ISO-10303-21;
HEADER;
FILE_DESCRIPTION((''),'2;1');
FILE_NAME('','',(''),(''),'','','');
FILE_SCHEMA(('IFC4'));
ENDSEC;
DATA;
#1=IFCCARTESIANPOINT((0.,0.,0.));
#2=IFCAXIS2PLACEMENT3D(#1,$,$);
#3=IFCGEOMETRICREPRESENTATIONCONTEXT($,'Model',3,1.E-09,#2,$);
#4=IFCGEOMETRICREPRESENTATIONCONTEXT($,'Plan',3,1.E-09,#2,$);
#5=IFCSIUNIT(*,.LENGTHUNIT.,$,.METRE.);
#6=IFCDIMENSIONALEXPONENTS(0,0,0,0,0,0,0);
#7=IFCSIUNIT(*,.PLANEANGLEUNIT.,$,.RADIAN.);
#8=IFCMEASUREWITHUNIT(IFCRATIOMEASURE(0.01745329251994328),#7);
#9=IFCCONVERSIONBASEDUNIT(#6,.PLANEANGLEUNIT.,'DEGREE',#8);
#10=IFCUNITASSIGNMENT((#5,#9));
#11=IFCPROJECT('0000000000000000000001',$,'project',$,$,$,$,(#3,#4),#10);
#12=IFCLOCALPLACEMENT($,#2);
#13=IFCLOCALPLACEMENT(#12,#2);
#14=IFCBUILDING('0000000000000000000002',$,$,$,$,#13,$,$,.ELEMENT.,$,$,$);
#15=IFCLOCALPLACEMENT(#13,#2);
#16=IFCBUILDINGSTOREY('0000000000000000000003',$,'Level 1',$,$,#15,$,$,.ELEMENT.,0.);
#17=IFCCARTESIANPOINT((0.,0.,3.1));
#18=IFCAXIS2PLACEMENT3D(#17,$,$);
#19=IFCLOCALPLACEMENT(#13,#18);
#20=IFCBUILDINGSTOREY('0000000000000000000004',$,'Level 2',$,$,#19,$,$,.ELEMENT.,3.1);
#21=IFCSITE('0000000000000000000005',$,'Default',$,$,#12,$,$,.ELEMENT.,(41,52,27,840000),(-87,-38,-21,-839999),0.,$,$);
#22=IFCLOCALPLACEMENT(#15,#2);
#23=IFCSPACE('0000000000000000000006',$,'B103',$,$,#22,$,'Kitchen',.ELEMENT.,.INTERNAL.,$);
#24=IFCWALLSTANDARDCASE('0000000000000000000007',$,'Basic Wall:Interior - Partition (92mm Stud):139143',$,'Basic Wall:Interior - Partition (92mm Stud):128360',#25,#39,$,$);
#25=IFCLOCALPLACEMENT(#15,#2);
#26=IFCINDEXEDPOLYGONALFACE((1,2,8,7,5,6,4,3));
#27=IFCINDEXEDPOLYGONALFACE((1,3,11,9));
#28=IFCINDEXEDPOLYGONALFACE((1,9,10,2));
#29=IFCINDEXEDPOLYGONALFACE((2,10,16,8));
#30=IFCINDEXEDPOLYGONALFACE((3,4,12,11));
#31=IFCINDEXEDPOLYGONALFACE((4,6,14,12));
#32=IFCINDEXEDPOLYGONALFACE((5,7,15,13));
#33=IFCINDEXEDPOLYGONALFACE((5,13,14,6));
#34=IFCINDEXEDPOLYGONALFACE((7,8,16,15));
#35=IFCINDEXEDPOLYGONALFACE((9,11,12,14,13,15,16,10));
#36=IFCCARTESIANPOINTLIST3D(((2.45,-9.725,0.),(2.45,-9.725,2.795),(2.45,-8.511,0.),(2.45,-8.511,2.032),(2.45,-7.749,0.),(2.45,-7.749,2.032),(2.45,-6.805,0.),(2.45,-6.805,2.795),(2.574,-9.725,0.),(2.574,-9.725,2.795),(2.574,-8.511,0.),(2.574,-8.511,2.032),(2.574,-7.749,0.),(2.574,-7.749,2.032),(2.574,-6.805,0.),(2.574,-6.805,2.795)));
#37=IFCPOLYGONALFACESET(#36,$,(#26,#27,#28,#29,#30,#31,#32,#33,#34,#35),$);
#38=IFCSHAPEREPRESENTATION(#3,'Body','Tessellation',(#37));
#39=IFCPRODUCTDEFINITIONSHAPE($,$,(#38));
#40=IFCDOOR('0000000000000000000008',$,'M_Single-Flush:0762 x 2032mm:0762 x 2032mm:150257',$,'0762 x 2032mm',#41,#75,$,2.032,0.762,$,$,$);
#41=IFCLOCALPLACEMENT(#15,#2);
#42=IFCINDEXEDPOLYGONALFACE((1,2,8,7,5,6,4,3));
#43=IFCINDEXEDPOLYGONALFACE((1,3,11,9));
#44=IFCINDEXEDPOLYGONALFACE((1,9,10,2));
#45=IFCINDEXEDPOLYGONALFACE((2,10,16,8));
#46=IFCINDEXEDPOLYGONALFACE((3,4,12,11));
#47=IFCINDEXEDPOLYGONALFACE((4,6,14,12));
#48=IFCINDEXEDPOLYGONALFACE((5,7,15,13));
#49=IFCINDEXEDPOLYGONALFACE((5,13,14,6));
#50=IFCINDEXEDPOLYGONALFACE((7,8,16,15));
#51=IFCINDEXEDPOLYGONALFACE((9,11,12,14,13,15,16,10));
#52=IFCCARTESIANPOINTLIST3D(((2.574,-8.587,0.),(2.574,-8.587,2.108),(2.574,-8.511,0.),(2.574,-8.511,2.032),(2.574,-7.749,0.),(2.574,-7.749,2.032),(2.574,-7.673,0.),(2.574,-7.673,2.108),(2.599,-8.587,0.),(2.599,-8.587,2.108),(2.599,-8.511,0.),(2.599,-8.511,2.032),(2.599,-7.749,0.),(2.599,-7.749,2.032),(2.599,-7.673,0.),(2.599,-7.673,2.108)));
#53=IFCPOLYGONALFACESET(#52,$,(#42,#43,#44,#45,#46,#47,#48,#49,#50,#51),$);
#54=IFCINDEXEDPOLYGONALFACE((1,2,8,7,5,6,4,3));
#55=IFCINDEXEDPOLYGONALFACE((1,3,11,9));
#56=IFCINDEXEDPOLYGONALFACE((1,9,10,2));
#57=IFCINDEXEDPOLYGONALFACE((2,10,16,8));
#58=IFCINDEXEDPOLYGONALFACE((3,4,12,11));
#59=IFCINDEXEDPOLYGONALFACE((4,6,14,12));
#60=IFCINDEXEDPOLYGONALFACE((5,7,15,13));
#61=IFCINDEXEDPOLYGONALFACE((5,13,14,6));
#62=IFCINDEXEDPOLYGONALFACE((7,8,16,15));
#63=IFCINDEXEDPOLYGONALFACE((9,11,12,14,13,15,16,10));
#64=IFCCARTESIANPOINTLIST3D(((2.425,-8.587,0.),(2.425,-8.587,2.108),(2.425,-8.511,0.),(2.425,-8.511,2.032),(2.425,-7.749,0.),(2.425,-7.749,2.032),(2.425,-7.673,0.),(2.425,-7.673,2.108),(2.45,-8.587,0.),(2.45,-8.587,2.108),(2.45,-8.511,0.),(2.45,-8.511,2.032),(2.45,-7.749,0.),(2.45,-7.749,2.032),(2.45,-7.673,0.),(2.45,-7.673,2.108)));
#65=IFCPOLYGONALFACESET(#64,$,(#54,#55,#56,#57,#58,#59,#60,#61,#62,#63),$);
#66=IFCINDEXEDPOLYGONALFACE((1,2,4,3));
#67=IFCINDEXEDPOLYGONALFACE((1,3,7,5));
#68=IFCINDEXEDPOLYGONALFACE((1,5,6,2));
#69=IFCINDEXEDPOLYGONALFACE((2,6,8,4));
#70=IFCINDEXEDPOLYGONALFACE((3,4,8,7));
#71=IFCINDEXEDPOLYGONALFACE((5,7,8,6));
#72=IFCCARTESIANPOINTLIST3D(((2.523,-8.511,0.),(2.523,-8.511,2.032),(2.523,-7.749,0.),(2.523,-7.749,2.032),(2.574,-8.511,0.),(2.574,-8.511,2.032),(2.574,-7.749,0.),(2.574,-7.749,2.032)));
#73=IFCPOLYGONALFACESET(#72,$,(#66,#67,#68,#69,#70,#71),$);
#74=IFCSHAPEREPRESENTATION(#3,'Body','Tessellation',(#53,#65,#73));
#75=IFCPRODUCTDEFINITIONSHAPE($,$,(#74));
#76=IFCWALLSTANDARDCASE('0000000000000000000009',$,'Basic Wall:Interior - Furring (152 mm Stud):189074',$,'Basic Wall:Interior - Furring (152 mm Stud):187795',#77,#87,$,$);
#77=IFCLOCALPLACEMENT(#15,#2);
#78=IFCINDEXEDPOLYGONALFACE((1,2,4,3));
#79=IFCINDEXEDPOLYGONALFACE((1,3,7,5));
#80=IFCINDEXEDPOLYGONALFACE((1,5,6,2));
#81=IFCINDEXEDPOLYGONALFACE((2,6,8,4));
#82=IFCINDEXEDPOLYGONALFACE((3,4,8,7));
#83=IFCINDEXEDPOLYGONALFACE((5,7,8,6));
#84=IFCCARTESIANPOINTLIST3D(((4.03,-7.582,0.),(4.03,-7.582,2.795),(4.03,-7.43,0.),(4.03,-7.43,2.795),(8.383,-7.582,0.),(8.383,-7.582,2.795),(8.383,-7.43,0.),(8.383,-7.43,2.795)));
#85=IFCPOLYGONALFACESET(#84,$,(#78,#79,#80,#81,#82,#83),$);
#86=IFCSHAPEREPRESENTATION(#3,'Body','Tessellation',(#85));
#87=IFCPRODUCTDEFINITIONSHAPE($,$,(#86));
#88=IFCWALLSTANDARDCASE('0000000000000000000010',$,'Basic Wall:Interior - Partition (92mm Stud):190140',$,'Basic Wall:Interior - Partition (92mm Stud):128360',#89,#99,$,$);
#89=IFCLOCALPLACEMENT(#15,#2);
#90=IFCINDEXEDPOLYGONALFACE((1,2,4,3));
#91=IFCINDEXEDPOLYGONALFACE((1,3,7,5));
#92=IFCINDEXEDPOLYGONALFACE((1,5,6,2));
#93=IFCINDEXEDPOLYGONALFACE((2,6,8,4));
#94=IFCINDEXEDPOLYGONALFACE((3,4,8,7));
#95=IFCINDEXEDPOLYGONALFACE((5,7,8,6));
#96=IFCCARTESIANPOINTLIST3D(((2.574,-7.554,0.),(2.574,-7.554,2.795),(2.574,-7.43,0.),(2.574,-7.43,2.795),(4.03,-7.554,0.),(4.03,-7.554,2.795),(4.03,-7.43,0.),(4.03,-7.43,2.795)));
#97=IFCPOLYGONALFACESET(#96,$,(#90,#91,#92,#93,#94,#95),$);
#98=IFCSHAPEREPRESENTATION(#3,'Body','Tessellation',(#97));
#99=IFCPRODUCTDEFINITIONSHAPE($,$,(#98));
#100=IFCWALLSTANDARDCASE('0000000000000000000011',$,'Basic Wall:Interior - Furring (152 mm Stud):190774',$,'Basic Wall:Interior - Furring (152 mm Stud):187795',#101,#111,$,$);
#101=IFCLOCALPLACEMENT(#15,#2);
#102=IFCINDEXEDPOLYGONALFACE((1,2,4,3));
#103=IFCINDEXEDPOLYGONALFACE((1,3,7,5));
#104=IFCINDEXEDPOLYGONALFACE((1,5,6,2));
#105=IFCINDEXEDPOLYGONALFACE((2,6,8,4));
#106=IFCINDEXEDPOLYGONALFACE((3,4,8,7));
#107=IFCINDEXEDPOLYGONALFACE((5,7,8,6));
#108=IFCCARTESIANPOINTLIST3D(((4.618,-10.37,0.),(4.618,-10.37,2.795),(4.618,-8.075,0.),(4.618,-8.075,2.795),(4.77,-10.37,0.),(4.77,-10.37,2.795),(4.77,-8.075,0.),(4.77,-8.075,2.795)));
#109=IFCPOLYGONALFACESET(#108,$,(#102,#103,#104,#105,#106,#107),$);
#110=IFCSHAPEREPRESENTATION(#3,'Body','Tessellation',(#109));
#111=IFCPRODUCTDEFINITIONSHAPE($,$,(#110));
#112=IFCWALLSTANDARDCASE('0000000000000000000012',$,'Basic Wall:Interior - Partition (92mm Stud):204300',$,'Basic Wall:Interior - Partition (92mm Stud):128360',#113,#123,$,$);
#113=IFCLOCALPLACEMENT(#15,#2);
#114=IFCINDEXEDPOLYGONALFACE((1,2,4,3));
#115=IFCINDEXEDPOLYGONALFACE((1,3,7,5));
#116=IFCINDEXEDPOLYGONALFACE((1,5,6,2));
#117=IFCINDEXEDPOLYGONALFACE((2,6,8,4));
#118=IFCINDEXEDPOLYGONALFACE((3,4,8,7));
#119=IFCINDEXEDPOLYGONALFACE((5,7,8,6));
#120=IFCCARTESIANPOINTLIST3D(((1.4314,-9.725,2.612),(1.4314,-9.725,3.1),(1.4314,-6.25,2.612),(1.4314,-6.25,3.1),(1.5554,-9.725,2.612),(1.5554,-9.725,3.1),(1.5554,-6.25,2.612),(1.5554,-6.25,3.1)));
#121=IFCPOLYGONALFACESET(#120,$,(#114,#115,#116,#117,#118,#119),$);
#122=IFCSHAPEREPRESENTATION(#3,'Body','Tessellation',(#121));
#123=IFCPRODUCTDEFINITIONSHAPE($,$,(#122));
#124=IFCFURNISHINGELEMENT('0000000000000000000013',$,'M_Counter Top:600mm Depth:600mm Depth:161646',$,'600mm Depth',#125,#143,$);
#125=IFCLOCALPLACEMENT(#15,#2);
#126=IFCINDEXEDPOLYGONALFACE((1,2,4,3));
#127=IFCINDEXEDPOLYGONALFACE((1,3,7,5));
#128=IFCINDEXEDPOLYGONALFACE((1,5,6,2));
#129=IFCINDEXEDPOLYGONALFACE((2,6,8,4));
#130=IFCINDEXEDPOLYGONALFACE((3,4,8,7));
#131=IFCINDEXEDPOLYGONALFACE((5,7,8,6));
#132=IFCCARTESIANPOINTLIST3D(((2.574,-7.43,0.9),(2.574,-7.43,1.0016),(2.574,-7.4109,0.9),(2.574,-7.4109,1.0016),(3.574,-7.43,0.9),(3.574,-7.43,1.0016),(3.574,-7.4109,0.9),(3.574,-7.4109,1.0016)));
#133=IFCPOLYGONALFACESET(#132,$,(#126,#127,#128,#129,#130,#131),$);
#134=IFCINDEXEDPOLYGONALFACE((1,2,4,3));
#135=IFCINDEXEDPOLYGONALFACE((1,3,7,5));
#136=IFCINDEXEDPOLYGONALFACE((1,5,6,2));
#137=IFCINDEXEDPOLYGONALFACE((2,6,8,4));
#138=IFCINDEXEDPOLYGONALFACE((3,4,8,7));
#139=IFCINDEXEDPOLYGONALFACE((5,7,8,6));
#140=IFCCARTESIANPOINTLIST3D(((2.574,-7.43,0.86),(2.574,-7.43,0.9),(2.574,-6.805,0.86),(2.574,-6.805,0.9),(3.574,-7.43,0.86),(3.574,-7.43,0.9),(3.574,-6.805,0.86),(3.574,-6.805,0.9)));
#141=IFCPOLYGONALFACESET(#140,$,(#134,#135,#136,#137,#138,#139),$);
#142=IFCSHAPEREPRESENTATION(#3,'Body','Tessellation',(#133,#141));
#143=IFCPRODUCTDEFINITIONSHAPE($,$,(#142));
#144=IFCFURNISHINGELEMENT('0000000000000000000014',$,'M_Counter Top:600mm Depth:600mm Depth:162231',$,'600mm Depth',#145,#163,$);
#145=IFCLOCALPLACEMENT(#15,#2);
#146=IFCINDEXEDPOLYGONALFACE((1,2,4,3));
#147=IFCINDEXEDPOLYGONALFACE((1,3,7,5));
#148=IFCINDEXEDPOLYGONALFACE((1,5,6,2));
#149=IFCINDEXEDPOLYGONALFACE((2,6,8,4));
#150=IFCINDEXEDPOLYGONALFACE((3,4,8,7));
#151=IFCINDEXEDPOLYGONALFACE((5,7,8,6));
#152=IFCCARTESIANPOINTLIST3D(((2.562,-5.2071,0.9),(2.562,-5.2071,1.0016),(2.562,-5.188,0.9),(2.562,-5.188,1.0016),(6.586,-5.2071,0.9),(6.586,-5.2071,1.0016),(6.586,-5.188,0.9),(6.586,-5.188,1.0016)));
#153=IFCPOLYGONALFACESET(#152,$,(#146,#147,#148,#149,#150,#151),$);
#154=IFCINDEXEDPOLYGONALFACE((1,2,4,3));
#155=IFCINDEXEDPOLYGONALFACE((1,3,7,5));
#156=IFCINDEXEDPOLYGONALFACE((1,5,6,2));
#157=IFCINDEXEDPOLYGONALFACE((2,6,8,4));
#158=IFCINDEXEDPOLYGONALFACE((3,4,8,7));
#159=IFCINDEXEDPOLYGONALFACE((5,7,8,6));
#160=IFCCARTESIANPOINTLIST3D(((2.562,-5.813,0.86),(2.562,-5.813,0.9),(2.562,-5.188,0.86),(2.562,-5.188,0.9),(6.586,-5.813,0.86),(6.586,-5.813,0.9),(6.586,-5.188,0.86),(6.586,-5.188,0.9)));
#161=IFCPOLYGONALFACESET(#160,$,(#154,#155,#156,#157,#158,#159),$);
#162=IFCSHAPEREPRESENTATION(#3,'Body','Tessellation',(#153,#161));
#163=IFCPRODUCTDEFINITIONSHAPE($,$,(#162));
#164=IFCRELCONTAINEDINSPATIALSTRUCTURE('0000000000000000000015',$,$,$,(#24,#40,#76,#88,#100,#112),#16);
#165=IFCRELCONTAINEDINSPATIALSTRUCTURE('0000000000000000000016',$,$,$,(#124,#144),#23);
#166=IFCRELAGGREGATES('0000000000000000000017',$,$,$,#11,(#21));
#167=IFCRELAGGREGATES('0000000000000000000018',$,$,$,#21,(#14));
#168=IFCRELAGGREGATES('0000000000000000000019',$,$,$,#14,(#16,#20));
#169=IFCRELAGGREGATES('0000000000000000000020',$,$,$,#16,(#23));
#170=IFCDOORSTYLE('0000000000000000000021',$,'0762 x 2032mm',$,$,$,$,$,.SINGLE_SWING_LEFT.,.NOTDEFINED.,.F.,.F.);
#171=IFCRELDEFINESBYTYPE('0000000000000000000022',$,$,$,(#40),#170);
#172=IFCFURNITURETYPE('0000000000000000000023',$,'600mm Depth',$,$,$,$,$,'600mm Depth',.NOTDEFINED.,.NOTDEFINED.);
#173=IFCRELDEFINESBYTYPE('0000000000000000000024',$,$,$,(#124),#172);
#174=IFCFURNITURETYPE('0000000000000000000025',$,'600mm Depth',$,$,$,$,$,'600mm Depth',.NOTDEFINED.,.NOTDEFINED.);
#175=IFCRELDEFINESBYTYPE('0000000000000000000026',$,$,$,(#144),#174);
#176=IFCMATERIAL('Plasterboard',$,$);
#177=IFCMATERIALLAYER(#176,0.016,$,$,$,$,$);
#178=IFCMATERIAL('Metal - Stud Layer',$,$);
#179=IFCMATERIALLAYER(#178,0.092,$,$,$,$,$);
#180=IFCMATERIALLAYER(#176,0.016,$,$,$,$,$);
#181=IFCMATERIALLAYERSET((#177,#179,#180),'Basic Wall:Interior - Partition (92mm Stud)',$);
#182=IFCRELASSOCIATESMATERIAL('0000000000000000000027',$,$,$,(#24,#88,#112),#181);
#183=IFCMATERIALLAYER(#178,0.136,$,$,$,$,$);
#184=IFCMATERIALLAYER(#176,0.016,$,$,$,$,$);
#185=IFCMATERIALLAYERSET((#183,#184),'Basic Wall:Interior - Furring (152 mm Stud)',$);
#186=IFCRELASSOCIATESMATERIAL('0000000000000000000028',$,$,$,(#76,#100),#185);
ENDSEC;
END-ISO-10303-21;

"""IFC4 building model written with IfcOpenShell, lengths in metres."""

from ifc_helpers import new_model, entity, si_unit, converted_unit, frame, frame_2d, origin, origin_2d_with_axis, place, context, project, spatial, polyline, rectangle, outline, extrude, clip, bounded_halfspace, source, transform, mapped, material, layer, layer_set, layer_usage, type_object, type_shapes, element, fill, save


model = new_model("IFC4")

# Units and contexts
model_context = context("Model", 3, precision=1e-09, world=origin())
plan_context = context("Plan", 3, precision=1e-09, world=origin())
ifc_project = project(units=[si_unit("LENGTHUNIT", "METRE"), converted_unit("PLANEANGLEUNIT", "DEGREE", entity("IfcRatioMeasure", 0.01745329251994328), si_unit("PLANEANGLEUNIT", "RADIAN"), dimensions=[0, 0, 0, 0, 0, 0, 0])], contexts=[model_context, plan_context])

# Site, building, storey
site_placement = place(None, origin())
site = spatial("IfcSite", under=ifc_project, at=site_placement, Name="Default", CompositionType="ELEMENT", RefLatitude=(41, 52, 27, 840000), RefLongitude=(-87, -38, -21, -839999), RefElevation=0.0)
building_placement = place(site_placement, origin())
building = spatial("IfcBuilding", under=site, at=building_placement, CompositionType="ELEMENT")
storey_1_placement = place(building_placement, origin())
storey_1 = spatial("IfcBuildingStorey", under=building, at=storey_1_placement, Name="Level 1", CompositionType="ELEMENT", Elevation=0.0)

# Shared definitions
ifc_material_1 = material(Name="Metal - Stud Layer")
ifc_material_2 = material(Name="Plasterboard")

# Shared definitions
ifc_layer_1 = layer(ifc_material_2, 0.016)
ifc_layer_2 = layer(ifc_material_1, 0.092)
ifc_layer_3 = layer(ifc_material_2, 0.016)
ifc_layer_set_1 = layer_set([ifc_layer_1, ifc_layer_2, ifc_layer_3], Name="Basic Wall:Interior - Partition (92mm Stud)")

# Wall, opening, door
ifc_layer_usage_1 = layer_usage(ifc_layer_set_1, "AXIS2", "NEGATIVE", 0.062)
wall_1_placement = place(storey_1_placement, frame((2.512, -6.805, 0.0), z_axis=(0.0, 0.0, 1.0), x_axis=(0.0, -1.0, 0.0)))
wall_1 = element("IfcWallStandardCase", 1, at=wall_1_placement, inside=storey_1, material=ifc_layer_usage_1, Name="Basic Wall:Interior - Partition (92mm Stud):139143", ObjectType="Basic Wall:Interior - Partition (92mm Stud):128360", context=model_context, shape_type="SweptSolid", body=[
    extrude(rectangle(XDim=2.92, YDim=0.124, at=frame_2d((1.46, 0.0), x_axis=(-1.0, 0.0))), origin(), (0.0, 0.0, 1.0), 2.795),
])
opening_1_placement = place(wall_1_placement, frame((0.944, -0.062, 0.0)))
opening_1 = element("IfcOpeningElement", 2, at=opening_1_placement, cuts=wall_1, ObjectType="Opening", context=model_context, shape_type="SweptSolid", body=[
    extrude(rectangle(XDim=0.762, YDim=2.032, at=frame_2d((1.016, 0.381), x_axis=(0.0, -1.0))), frame((0.0, 0.0, 0.0), z_axis=(0.0, 1.0, 0.0), x_axis=(0.0, 0.0, 1.0)), (0.0, 0.0, 1.0), 0.124),
])
door_style_1 = type_object("IfcDoorStyle", Name="0762 x 2032mm", ConstructionType="NOTDEFINED", OperationType="SINGLE_SWING_LEFT", ParameterTakesPrecedence=False, Sizeable=False)
shared_shape_1 = source(origin(), model_context, "Body", "SweptSolid", [
    extrude(outline(polyline([(-0.457, -1.073), (0.457, -1.073), (0.457, 1.035), (0.381, 1.035), (0.381, -0.997), (-0.381, -0.997), (-0.381, 1.035), (-0.457, 1.035), (-0.457, -1.073)])), frame((0.381, 0.149, 1.035), z_axis=(0.0, -1.0, 0.0), x_axis=(-1.0, 0.0, 0.0)), (0.0, 0.0, 1.0), 0.025),
    extrude(outline(polyline([(-1.073, -0.457), (1.035, -0.457), (1.035, -0.381), (-0.997, -0.381), (-0.997, 0.381), (1.035, 0.381), (1.035, 0.457), (-1.073, 0.457), (-1.073, -0.457)])), frame((0.381, 0.0, 1.035), z_axis=(0.0, -1.0, 0.0), x_axis=(0.0, 0.0, -1.0)), (0.0, 0.0, 1.0), 0.025),
    extrude(rectangle(XDim=0.762, YDim=0.051, at=origin_2d_with_axis()), frame((0.381, 0.0985, 0.0)), (0.0, 0.0, 1.0), 2.032),
])
type_shapes(door_style_1, [shared_shape_1])
door_1_placement = place(opening_1_placement, origin())
door_1 = element("IfcDoor", 3, at=door_1_placement, inside=storey_1, type_object=door_style_1, Name="M_Single-Flush:0762 x 2032mm:0762 x 2032mm:150257", ObjectType="0762 x 2032mm", OverallHeight=2.032, OverallWidth=0.762, context=model_context, shape_type="MappedRepresentation", body=[
    mapped(shared_shape_1, transform((0.0, 0.0, 0.0), scale=1.0)),
])
fill(opening_1, door_1)

# Shared definitions
storey_2_placement = place(building_placement, frame((0.0, 0.0, 3.1)))
storey_2 = spatial("IfcBuildingStorey", under=building, at=storey_2_placement, Name="Level 2", CompositionType="ELEMENT", Elevation=3.1)

# Walls
ifc_layer_4 = layer(ifc_material_1, 0.136)
ifc_layer_5 = layer(ifc_material_2, 0.016)
ifc_layer_set_2 = layer_set([ifc_layer_4, ifc_layer_5], Name="Basic Wall:Interior - Furring (152 mm Stud)")
ifc_layer_usage_2 = layer_usage(ifc_layer_set_2, "AXIS2", "NEGATIVE", 0.076)
wall_2_placement = place(storey_1_placement, frame((8.383, -7.506, 0.0), z_axis=(0.0, 0.0, 1.0), x_axis=(-1.0, 0.0, 0.0)))
element("IfcWallStandardCase", 4, at=wall_2_placement, inside=storey_1, material=ifc_layer_usage_2, Name="Basic Wall:Interior - Furring (152 mm Stud):189074", ObjectType="Basic Wall:Interior - Furring (152 mm Stud):187795", context=model_context, shape_type="Clipping", body=[
    clip(extrude(rectangle(XDim=4.353, YDim=0.152, at=frame_2d((2.1765, 0.0), x_axis=(-1.0, 0.0))), origin(), (0.0, 0.0, 1.0), 2.795), bounded_halfspace(frame((0.0, -0.076, 2.795), z_axis=(0.0, 0.0, -1.0), x_axis=(0.0, 1.0, 0.0)), True, frame((0.0, -0.076, 2.795)), polyline([(0.0, 0.0), (3.708, 0.0), (3.708, 0.152), (0.0, 0.152), (0.0, 0.0)]))),
])
ifc_layer_usage_3 = layer_usage(ifc_layer_set_1, "AXIS2", "NEGATIVE", 0.062)
wall_3_placement = place(storey_1_placement, frame((4.03, -7.492, 0.0), z_axis=(0.0, 0.0, 1.0), x_axis=(-1.0, 0.0, 0.0)))
element("IfcWallStandardCase", 5, at=wall_3_placement, inside=storey_1, material=ifc_layer_usage_3, Name="Basic Wall:Interior - Partition (92mm Stud):190140", ObjectType="Basic Wall:Interior - Partition (92mm Stud):128360", context=model_context, shape_type="SweptSolid", body=[
    extrude(rectangle(XDim=1.456, YDim=0.124, at=frame_2d((0.728, 0.0), x_axis=(-1.0, 0.0))), origin(), (0.0, 0.0, 1.0), 2.795),
])
ifc_layer_usage_4 = layer_usage(ifc_layer_set_2, "AXIS2", "POSITIVE", -0.076)
wall_4_placement = place(storey_1_placement, frame((4.694, -8.075, 0.0), z_axis=(0.0, 0.0, 1.0), x_axis=(0.0, -1.0, 0.0)))
element("IfcWallStandardCase", 6, at=wall_4_placement, inside=storey_1, material=ifc_layer_usage_4, Name="Basic Wall:Interior - Furring (152 mm Stud):190774", ObjectType="Basic Wall:Interior - Furring (152 mm Stud):187795", context=model_context, shape_type="SweptSolid", body=[
    extrude(rectangle(XDim=2.295, YDim=0.152, at=frame_2d((1.1475, 0.0), x_axis=(-1.0, 0.0))), origin(), (0.0, 0.0, 1.0), 2.795),
])
ifc_layer_usage_5 = layer_usage(ifc_layer_set_1, "AXIS2", "NEGATIVE", 0.062)
wall_5_placement = place(storey_1_placement, frame((1.4934, -6.25, 2.612), z_axis=(0.0, 0.0, 1.0), x_axis=(0.0, -1.0, 0.0)))
element("IfcWallStandardCase", 7, at=wall_5_placement, inside=storey_1, material=ifc_layer_usage_5, Name="Basic Wall:Interior - Partition (92mm Stud):204300", ObjectType="Basic Wall:Interior - Partition (92mm Stud):128360", context=model_context, shape_type="SweptSolid", body=[
    extrude(rectangle(XDim=3.475, YDim=0.124, at=frame_2d((1.7375, 0.0), x_axis=(-1.0, 0.0))), origin(), (0.0, 0.0, 1.0), 0.488),
])

# Shared definitions
space_1_placement = place(storey_1_placement, origin())
space_1 = spatial("IfcSpace", under=storey_1, at=space_1_placement, Name="B103", LongName="Kitchen", CompositionType="ELEMENT", PredefinedType="INTERNAL")

# Furnishing elements
furniture_type_1 = type_object("IfcFurnitureType", Name="600mm Depth", ElementType="600mm Depth", AssemblyPlace="NOTDEFINED")
shared_shape_2 = source(origin(), model_context, "Body", "SweptSolid", [
    extrude(rectangle(XDim=0.0191, YDim=1.0, at=origin_2d_with_axis()), frame((-0.7005, -0.0095, 0.9), z_axis=(0.0, 0.0, 1.0), x_axis=(0.0, -1.0, 0.0)), (0.0, 0.0, 1.0), 0.1016),
    extrude(rectangle(XDim=1.0, YDim=0.625, at=origin_2d_with_axis()), frame((-0.7005, -0.3125, 0.86), z_axis=(0.0, 0.0, 1.0), x_axis=(-1.0, 0.0, 0.0)), (0.0, 0.0, 1.0), 0.04),
])
type_shapes(furniture_type_1, [shared_shape_2])
furnishing_1_placement = place(space_1_placement, frame((2.3735, -7.43, 0.0), z_axis=(0.0, 0.0, 1.0), x_axis=(-1.0, 0.0, 0.0)))
element("IfcFurnishingElement", 8, at=furnishing_1_placement, inside=space_1, type_object=furniture_type_1, Name="M_Counter Top:600mm Depth:600mm Depth:161646", ObjectType="600mm Depth", context=model_context, shape_type="MappedRepresentation", body=[
    mapped(shared_shape_2, transform((0.0, 0.0, 0.0), scale=1.0)),
])
furniture_type_2 = type_object("IfcFurnitureType", Name="600mm Depth", ElementType="600mm Depth", AssemblyPlace="NOTDEFINED")
shared_shape_3 = source(origin(), model_context, "Body", "SweptSolid", [
    extrude(rectangle(XDim=0.0191, YDim=4.024, at=origin_2d_with_axis()), frame((0.8115, -0.0095, 0.9), z_axis=(0.0, 0.0, 1.0), x_axis=(0.0, -1.0, 0.0)), (0.0, 0.0, 1.0), 0.1016),
    extrude(rectangle(XDim=4.024, YDim=0.625, at=origin_2d_with_axis()), frame((0.8115, -0.3125, 0.86), z_axis=(0.0, 0.0, 1.0), x_axis=(-1.0, 0.0, 0.0)), (0.0, 0.0, 1.0), 0.04),
])
type_shapes(furniture_type_2, [shared_shape_3])
furnishing_2_placement = place(space_1_placement, frame((3.7625, -5.188, 0.0)))
element("IfcFurnishingElement", 9, at=furnishing_2_placement, inside=space_1, type_object=furniture_type_2, Name="M_Counter Top:600mm Depth:600mm Depth:162231", ObjectType="600mm Depth", context=model_context, shape_type="MappedRepresentation", body=[
    mapped(shared_shape_3, transform((0.0, 0.0, 0.0), scale=1.0)),
])

save(model, "model.ifc")
